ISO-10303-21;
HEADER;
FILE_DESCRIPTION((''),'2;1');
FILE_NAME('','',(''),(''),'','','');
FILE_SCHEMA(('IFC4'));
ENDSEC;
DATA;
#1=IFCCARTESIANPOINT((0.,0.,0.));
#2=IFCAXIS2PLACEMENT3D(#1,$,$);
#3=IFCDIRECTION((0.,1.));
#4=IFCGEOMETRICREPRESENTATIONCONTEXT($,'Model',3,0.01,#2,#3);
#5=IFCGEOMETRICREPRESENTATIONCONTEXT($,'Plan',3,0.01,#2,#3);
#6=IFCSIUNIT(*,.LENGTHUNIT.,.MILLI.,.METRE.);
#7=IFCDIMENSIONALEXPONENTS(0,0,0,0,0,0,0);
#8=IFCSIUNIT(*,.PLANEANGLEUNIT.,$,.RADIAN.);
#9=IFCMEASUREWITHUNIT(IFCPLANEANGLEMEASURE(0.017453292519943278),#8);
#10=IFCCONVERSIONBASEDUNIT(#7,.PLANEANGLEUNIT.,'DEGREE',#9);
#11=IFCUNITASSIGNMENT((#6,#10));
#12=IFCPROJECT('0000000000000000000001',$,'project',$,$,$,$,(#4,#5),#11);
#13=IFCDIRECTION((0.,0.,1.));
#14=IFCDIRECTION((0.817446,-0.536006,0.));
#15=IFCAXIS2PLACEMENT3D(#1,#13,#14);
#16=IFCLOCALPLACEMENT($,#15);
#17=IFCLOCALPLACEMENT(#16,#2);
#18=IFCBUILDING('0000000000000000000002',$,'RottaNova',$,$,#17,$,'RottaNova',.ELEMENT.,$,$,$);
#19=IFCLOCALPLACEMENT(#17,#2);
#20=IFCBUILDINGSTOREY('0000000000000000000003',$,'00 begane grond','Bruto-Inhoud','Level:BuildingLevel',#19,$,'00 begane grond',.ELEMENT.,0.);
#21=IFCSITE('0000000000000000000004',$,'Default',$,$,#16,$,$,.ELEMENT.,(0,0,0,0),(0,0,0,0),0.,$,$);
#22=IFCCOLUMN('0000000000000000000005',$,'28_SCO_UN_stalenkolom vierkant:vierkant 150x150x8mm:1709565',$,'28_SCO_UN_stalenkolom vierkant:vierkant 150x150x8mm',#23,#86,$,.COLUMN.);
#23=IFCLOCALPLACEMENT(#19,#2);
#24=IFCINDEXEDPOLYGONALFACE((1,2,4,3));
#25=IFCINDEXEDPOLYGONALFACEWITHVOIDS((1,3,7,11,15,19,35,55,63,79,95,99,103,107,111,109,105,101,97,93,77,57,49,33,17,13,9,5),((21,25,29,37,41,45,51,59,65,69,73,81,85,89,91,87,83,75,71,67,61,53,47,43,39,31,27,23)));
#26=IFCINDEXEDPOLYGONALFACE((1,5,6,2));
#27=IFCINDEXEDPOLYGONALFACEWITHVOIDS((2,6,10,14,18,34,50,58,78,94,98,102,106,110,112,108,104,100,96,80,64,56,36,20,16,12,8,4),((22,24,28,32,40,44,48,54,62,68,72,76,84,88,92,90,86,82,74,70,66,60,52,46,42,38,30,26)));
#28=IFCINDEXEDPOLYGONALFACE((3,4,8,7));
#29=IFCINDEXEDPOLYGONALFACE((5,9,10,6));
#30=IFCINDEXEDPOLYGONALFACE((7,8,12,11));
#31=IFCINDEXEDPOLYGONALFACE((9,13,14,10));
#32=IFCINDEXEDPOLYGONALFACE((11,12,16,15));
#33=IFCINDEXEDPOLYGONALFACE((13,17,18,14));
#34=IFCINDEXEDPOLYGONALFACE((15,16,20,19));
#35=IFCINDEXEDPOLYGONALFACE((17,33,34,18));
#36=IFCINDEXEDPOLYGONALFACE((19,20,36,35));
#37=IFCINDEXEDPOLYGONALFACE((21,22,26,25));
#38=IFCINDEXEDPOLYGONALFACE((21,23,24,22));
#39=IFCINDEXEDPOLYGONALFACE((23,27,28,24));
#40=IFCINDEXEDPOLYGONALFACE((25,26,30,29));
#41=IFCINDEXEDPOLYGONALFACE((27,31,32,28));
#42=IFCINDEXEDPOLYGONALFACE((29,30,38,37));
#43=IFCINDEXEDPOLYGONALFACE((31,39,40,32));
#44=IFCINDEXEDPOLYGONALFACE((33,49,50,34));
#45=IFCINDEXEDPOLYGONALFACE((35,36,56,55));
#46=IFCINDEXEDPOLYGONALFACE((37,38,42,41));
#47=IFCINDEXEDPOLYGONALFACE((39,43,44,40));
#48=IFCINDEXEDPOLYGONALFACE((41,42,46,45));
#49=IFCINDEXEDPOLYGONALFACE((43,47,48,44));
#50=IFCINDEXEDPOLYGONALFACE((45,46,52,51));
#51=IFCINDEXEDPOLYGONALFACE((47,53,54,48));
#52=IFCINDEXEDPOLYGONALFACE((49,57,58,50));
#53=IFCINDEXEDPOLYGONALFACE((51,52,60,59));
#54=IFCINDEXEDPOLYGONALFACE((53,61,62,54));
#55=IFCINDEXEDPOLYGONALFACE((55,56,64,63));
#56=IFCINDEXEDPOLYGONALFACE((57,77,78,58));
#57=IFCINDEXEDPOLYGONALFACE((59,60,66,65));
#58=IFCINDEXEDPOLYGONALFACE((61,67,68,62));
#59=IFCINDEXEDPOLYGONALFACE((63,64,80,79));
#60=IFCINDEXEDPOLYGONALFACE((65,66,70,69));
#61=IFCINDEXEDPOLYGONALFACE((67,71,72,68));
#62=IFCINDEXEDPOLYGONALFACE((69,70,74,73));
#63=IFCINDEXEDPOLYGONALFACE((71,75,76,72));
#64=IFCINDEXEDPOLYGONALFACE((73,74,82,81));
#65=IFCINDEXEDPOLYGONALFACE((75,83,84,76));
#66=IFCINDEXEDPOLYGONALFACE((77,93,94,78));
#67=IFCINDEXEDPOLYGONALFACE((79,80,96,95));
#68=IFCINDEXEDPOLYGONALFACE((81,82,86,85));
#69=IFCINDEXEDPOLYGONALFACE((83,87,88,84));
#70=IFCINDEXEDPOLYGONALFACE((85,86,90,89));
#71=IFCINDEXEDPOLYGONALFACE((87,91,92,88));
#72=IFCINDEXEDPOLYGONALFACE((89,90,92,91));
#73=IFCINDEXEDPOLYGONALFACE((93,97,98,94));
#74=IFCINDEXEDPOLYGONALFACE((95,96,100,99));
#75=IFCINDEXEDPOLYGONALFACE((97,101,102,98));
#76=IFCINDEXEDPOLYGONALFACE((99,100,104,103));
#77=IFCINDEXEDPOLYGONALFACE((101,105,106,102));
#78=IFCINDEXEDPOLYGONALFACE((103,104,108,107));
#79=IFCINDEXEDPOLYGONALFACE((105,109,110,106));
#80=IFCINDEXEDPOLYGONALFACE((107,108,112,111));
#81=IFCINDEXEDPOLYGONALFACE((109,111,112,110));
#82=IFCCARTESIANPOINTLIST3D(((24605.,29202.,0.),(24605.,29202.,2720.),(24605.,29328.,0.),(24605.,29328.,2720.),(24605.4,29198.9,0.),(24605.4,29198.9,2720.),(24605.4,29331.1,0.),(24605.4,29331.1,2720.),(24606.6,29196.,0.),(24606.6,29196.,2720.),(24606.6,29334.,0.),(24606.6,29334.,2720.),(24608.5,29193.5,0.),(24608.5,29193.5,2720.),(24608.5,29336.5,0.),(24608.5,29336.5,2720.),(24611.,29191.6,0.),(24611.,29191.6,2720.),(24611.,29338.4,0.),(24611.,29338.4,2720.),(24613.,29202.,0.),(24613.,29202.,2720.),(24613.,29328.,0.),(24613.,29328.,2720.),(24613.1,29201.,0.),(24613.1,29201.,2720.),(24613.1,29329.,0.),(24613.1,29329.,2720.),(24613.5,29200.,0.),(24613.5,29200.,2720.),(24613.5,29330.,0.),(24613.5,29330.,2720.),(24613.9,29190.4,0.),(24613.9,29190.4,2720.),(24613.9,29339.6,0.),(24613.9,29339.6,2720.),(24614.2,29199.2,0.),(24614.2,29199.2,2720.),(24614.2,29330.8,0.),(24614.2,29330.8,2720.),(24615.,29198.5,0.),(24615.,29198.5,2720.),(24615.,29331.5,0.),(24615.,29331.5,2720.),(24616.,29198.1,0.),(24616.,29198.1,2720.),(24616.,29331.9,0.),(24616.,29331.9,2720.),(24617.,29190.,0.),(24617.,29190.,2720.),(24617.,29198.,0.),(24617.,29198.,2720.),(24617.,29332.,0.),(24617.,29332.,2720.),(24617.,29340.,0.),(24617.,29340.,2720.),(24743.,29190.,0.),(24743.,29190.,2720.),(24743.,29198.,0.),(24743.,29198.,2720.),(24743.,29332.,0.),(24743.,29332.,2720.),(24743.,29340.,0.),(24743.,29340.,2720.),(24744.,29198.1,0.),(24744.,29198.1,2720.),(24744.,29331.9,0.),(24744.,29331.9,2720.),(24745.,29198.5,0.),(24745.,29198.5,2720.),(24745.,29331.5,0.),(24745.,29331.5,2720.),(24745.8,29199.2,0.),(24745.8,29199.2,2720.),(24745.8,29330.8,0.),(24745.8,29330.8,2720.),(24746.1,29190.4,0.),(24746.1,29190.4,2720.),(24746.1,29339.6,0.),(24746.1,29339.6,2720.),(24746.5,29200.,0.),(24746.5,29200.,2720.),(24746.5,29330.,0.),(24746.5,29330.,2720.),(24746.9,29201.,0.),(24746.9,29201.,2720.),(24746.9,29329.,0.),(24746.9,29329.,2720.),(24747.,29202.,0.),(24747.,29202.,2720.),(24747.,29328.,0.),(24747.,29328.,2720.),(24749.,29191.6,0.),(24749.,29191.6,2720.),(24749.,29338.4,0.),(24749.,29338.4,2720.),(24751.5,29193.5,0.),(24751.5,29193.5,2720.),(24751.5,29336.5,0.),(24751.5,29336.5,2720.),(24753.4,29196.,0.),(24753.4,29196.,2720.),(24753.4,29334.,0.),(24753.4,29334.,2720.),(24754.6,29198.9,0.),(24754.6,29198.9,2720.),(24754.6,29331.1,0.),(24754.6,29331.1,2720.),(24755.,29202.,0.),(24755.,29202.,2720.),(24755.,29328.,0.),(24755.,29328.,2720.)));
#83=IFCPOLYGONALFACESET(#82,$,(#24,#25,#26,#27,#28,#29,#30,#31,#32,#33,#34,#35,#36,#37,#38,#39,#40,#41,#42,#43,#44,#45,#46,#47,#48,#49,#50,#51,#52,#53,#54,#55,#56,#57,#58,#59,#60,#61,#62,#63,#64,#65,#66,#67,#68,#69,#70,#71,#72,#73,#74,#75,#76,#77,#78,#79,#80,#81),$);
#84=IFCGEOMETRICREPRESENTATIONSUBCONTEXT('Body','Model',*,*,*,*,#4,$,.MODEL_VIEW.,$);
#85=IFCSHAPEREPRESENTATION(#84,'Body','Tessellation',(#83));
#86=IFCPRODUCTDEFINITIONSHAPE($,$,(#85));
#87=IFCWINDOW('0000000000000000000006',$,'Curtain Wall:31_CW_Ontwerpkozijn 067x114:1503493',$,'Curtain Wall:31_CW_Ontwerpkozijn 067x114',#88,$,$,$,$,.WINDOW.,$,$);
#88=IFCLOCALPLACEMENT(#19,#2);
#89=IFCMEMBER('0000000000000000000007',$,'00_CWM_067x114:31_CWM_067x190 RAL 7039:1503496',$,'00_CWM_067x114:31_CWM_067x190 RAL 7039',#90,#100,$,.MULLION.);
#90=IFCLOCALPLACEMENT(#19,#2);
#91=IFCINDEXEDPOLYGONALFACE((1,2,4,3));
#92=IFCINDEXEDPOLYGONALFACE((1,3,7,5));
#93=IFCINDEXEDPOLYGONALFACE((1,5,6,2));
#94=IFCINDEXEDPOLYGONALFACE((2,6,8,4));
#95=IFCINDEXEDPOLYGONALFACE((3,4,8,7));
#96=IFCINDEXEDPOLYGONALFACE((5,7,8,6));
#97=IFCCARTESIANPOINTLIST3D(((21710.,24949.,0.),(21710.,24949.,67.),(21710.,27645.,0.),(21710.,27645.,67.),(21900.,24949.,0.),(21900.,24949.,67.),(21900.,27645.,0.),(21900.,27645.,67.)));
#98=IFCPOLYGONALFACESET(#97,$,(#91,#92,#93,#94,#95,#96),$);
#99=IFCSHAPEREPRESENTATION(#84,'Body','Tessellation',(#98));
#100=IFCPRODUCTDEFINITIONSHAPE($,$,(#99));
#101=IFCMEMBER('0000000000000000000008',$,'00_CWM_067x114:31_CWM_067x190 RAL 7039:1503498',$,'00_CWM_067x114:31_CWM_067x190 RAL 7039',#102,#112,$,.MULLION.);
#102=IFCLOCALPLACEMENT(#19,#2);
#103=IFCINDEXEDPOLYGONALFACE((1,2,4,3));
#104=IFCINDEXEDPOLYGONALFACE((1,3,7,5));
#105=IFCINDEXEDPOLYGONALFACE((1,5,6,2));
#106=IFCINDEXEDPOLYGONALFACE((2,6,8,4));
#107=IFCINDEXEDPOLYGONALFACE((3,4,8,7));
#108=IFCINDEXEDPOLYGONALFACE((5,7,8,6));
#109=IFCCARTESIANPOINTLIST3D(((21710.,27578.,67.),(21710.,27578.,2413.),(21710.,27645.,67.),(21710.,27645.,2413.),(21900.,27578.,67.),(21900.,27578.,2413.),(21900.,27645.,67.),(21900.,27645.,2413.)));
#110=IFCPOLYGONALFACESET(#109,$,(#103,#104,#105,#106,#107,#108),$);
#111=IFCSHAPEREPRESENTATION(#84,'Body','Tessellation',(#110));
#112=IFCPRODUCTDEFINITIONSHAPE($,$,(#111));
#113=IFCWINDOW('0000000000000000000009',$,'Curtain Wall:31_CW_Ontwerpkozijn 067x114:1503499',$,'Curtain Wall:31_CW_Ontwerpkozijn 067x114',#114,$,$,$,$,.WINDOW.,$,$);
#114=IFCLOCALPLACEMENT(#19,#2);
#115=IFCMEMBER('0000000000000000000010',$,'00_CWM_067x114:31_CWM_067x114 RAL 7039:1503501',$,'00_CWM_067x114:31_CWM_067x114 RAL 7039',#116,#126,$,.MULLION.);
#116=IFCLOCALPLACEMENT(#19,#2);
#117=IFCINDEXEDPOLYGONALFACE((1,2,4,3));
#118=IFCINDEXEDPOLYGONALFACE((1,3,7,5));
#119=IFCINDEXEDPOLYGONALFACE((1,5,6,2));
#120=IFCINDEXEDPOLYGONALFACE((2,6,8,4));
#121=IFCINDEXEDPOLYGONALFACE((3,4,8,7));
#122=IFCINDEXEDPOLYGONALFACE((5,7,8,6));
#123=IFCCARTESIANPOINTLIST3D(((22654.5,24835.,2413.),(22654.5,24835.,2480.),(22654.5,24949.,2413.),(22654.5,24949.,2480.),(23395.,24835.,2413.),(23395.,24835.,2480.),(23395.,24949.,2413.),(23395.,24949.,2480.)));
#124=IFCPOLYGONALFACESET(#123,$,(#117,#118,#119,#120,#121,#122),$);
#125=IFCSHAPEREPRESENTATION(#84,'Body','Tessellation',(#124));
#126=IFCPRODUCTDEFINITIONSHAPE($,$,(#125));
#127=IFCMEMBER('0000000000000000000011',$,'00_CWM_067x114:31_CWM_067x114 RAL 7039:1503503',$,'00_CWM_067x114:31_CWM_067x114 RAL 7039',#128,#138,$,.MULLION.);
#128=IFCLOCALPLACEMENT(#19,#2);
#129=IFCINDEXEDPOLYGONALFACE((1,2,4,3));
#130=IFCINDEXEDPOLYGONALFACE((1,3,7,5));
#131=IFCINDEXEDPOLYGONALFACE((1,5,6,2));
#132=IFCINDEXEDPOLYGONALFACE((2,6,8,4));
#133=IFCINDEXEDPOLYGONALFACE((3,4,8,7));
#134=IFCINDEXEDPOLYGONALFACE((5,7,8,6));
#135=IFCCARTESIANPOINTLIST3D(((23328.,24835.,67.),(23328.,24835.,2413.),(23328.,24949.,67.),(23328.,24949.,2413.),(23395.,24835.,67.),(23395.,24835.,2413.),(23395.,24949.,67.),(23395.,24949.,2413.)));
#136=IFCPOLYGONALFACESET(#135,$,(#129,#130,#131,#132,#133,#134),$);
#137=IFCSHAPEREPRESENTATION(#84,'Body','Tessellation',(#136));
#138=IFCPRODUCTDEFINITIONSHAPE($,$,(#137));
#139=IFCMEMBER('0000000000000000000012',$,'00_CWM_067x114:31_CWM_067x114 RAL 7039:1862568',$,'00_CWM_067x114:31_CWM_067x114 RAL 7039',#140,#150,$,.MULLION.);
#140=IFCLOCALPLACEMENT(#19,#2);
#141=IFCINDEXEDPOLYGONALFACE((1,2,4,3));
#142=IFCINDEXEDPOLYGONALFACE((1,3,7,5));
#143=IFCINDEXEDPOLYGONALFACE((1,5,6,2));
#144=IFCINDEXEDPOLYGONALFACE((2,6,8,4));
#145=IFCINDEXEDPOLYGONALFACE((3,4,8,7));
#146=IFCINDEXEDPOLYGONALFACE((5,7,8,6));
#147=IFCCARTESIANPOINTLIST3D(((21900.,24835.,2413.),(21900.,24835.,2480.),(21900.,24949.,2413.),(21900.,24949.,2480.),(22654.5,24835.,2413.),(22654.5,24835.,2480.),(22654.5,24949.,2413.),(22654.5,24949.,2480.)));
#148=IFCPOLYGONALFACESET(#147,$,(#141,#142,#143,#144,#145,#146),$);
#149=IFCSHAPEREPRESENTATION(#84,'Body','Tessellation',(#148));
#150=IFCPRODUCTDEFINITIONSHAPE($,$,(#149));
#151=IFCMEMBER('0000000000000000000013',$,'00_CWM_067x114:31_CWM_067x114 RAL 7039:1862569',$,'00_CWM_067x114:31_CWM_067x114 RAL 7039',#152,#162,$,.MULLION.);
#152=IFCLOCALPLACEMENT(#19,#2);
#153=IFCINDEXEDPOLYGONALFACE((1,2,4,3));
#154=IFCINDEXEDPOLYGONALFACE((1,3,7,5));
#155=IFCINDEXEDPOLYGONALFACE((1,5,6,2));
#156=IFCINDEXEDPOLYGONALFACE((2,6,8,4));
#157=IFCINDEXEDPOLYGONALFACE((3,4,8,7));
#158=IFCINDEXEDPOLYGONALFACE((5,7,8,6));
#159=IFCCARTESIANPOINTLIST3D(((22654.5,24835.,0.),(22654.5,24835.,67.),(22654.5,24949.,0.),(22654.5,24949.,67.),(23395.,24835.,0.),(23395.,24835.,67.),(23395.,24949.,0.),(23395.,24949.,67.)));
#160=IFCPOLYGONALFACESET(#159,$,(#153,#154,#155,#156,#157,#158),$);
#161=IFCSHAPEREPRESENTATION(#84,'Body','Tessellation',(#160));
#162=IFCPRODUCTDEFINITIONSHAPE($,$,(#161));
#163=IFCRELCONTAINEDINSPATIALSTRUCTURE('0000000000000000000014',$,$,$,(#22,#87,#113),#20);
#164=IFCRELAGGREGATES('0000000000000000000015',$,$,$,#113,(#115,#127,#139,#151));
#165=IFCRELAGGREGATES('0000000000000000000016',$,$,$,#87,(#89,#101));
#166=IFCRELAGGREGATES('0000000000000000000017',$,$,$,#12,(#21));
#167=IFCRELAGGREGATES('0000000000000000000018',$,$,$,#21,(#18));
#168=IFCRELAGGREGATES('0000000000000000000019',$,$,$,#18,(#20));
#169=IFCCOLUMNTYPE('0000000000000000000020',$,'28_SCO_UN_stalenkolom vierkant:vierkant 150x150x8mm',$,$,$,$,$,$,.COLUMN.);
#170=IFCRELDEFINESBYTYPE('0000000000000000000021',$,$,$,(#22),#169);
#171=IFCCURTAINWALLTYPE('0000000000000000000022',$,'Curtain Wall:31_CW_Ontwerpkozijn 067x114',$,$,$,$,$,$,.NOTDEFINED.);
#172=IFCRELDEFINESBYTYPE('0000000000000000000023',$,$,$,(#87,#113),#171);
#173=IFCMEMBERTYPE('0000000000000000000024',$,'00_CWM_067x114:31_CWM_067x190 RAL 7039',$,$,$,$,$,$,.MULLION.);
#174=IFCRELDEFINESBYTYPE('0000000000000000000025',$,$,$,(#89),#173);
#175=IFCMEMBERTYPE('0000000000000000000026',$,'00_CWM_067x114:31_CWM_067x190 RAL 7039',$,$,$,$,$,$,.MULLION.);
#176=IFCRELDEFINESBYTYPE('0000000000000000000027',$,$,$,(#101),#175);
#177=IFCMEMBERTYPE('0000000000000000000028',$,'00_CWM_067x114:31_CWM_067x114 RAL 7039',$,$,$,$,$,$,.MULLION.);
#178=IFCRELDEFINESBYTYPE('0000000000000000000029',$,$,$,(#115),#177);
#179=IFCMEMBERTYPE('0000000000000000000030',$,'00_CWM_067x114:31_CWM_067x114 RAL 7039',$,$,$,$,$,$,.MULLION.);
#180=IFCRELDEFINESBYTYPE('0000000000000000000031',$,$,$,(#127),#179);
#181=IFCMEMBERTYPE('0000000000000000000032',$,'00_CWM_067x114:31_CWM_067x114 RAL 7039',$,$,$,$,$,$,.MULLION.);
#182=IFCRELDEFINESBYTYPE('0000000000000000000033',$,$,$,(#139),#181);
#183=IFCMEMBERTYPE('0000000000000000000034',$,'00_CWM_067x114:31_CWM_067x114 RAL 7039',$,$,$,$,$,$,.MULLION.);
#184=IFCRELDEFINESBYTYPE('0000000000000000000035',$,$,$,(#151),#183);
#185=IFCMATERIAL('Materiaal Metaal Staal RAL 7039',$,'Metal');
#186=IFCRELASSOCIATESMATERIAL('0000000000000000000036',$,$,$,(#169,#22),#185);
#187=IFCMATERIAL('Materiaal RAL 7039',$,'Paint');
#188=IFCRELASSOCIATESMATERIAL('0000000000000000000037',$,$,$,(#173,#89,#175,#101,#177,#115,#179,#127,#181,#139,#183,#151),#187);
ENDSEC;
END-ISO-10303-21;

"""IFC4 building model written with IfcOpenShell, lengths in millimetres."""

from ifc_helpers import new_model, entity, si_unit, converted_unit, direction, frame, origin, place, context, subcontext, project, spatial, line, arc, indexed_curve, outline, extrude, source, transform, mapped, material, type_object, type_shapes, element, aggregate, save


model = new_model("IFC4")

# Units and contexts
model_context = context("Model", 3, precision=0.01, world=origin(), true_north=direction((0.0, 1.0)))
plan_context = context("Plan", 3, precision=0.01, world=origin(), true_north=direction((0.0, 1.0)))
body_context = subcontext(model_context, "Body", "Model", "MODEL_VIEW")
ifc_project = project(units=[si_unit("LENGTHUNIT", "METRE", prefix="MILLI"), converted_unit("PLANEANGLEUNIT", "DEGREE", entity("IfcPlaneAngleMeasure", 0.017453292519943278), si_unit("PLANEANGLEUNIT", "RADIAN"), dimensions=[0, 0, 0, 0, 0, 0, 0])], contexts=[model_context, plan_context])

# Site, building, storey
site_placement = place(None, frame((0.0, 0.0, 0.0), z_axis=(0.0, 0.0, 1.0), x_axis=(0.817446, -0.536006, 0.0)))
site = spatial("IfcSite", under=ifc_project, at=site_placement, Name="Default", CompositionType="ELEMENT", RefLatitude=(0, 0, 0, 0), RefLongitude=(0, 0, 0, 0), RefElevation=0.0)
building_placement = place(site_placement, origin())
building = spatial("IfcBuilding", under=site, at=building_placement, Name="RottaNova", LongName="RottaNova", CompositionType="ELEMENT")
storey_placement = place(building_placement, origin())
storey = spatial("IfcBuildingStorey", under=building, at=storey_placement, Name="00 begane grond", Description="Bruto-Inhoud", ObjectType="Level:BuildingLevel", LongName="00 begane grond", CompositionType="ELEMENT", Elevation=0.0)

# Column
ifc_material_1 = material(Name="Materiaal Metaal Staal RAL 7039", Category="Metal")
column_type = type_object("IfcColumnType", Name="28_SCO_UN_stalenkolom vierkant:vierkant 150x150x8mm", PredefinedType="COLUMN", material=ifc_material_1)
shared_shape_1 = source(origin(), body_context, "Body", "SweptSolid", [
    extrude(outline(indexed_curve([(-63.0, -75.0), (63.0, -75.0), (71.5, -71.5), (75.0, -63.0), (75.0, 63.0), (71.5, 71.5), (63.0, 75.0), (-63.0, 75.0), (-71.5, 71.5), (-75.0, 63.0), (-75.0, -63.0), (-71.5, -71.5)], segments=[line(1, 2), arc(2, 3, 4), line(4, 5), arc(5, 6, 7), line(7, 8), arc(8, 9, 10), line(10, 11), arc(11, 12, 1)], self_intersect=False), holes=[indexed_curve([(67.0, -63.0), (65.8, -65.8), (63.0, -67.0), (-63.0, -67.0), (-65.8, -65.8), (-67.0, -63.0), (-67.0, 63.0), (-65.8, 65.8), (-63.0, 67.0), (63.0, 67.0), (65.8, 65.8), (67.0, 63.0)], segments=[arc(1, 2, 3), line(3, 4), arc(4, 5, 6), line(6, 7), arc(7, 8, 9), line(9, 10), arc(10, 11, 12), line(12, 1)], self_intersect=False)]), frame((0.0, 0.0, 0.0), z_axis=(0.0, 0.0, 1.0), x_axis=(-1.0, 0.0, 0.0)), (0.0, 0.0, 1.0), 2720.0),
])
type_shapes(column_type, [shared_shape_1])
column_placement = place(storey_placement, frame((24680.0, 29265.0, 0.0)))
element("IfcColumn", 1, at=column_placement, inside=storey, type_object=column_type, material=ifc_material_1, Name="28_SCO_UN_stalenkolom vierkant:vierkant 150x150x8mm:1709565", ObjectType="28_SCO_UN_stalenkolom vierkant:vierkant 150x150x8mm", PredefinedType="COLUMN", context=body_context, shape_type="MappedRepresentation", body=[
    mapped(shared_shape_1, transform((0.0, 0.0, 0.0), scale=1.0)),
])

# Window, members
curtain_wall_type = type_object("IfcCurtainWallType", Name="Curtain Wall:31_CW_Ontwerpkozijn 067x114", PredefinedType="NOTDEFINED")
window_1_placement = place(storey_placement, origin())
window_1 = element("IfcWindow", 2, at=window_1_placement, inside=storey, type_object=curtain_wall_type, Name="Curtain Wall:31_CW_Ontwerpkozijn 067x114:1503493", ObjectType="Curtain Wall:31_CW_Ontwerpkozijn 067x114", PredefinedType="WINDOW")
ifc_material_2 = material(Name="Materiaal RAL 7039", Category="Paint")
member_type_1 = type_object("IfcMemberType", Name="00_CWM_067x114:31_CWM_067x190 RAL 7039", PredefinedType="MULLION", material=ifc_material_2)
shared_shape_2 = source(origin(), body_context, "Body", "SweptSolid", [
    extrude(outline(indexed_curve([(-33.5, -95.0), (33.5, -95.0), (33.5, 95.0), (-33.5, 95.0), (-33.5, -95.0)], self_intersect=False)), frame((-33.5, -95.0, -2696.0), z_axis=(0.0, 0.0, 1.0), x_axis=(-1.0, 0.0, 0.0)), (0.0, 0.0, 1.0), 2696.0),
])
type_shapes(member_type_1, [shared_shape_2])
member_1_placement = place(window_1_placement, frame((21710.0, 27645.0, 0.0), z_axis=(0.0, 1.0, 0.0), x_axis=(0.0, 0.0, -1.0)))
member_1 = element("IfcMember", 3, at=member_1_placement, type_object=member_type_1, material=ifc_material_2, Name="00_CWM_067x114:31_CWM_067x190 RAL 7039:1503496", ObjectType="00_CWM_067x114:31_CWM_067x190 RAL 7039", PredefinedType="MULLION", context=body_context, shape_type="MappedRepresentation", body=[
    mapped(shared_shape_2, transform((0.0, 0.0, 0.0), scale=1.0)),
])
member_type_2 = type_object("IfcMemberType", Name="00_CWM_067x114:31_CWM_067x190 RAL 7039", PredefinedType="MULLION", material=ifc_material_2)
shared_shape_3 = source(origin(), body_context, "Body", "SweptSolid", [
    extrude(outline(indexed_curve([(-33.5, -95.0), (33.5, -95.0), (33.5, 95.0), (-33.5, 95.0), (-33.5, -95.0)], self_intersect=False)), frame((-33.5, -95.0, -2346.0), z_axis=(0.0, 0.0, 1.0), x_axis=(-1.0, 0.0, 0.0)), (0.0, 0.0, 1.0), 2346.0),
])
type_shapes(member_type_2, [shared_shape_3])
member_2_placement = place(window_1_placement, frame((21710.0, 27645.0, 2413.0), z_axis=(0.0, 0.0, 1.0), x_axis=(0.0, 1.0, 0.0)))
member_2 = element("IfcMember", 4, at=member_2_placement, type_object=member_type_2, material=ifc_material_2, Name="00_CWM_067x114:31_CWM_067x190 RAL 7039:1503498", ObjectType="00_CWM_067x114:31_CWM_067x190 RAL 7039", PredefinedType="MULLION", context=body_context, shape_type="MappedRepresentation", body=[
    mapped(shared_shape_3, transform((0.0, 0.0, 0.0), scale=1.0)),
])

# Window, members
window_2_placement = place(storey_placement, origin())
window_2 = element("IfcWindow", 5, at=window_2_placement, inside=storey, type_object=curtain_wall_type, Name="Curtain Wall:31_CW_Ontwerpkozijn 067x114:1503499", ObjectType="Curtain Wall:31_CW_Ontwerpkozijn 067x114", PredefinedType="WINDOW")
member_type_3 = type_object("IfcMemberType", Name="00_CWM_067x114:31_CWM_067x114 RAL 7039", PredefinedType="MULLION", material=ifc_material_2)
shared_shape_4 = source(origin(), body_context, "Body", "SweptSolid", [
    extrude(outline(indexed_curve([(-33.5, -57.0), (33.5, -57.0), (33.5, 57.0), (-33.5, 57.0), (-33.5, -57.0)], self_intersect=False)), frame((-33.5, -57.0, -740.5), z_axis=(0.0, 0.0, 1.0), x_axis=(-1.0, 0.0, 0.0)), (0.0, 0.0, 1.0), 740.5),
])
type_shapes(member_type_3, [shared_shape_4])
member_3_placement = place(window_2_placement, frame((23395.0, 24835.0, 2480.0), z_axis=(1.0, 0.0, 0.0), x_axis=(0.0, 0.0, 1.0)))
member_3 = element("IfcMember", 6, at=member_3_placement, type_object=member_type_3, material=ifc_material_2, Name="00_CWM_067x114:31_CWM_067x114 RAL 7039:1503501", ObjectType="00_CWM_067x114:31_CWM_067x114 RAL 7039", PredefinedType="MULLION", context=body_context, shape_type="MappedRepresentation", body=[
    mapped(shared_shape_4, transform((0.0, 0.0, 0.0), scale=1.0)),
])
member_type_4 = type_object("IfcMemberType", Name="00_CWM_067x114:31_CWM_067x114 RAL 7039", PredefinedType="MULLION", material=ifc_material_2)
shared_shape_5 = source(origin(), body_context, "Body", "SweptSolid", [
    extrude(outline(indexed_curve([(-33.5, -57.0), (33.5, -57.0), (33.5, 57.0), (-33.5, 57.0), (-33.5, -57.0)], self_intersect=False)), frame((-33.5, -57.0, -2346.0), z_axis=(0.0, 0.0, 1.0), x_axis=(-1.0, 0.0, 0.0)), (0.0, 0.0, 1.0), 2346.0),
])
type_shapes(member_type_4, [shared_shape_5])
member_4_placement = place(window_2_placement, frame((23395.0, 24835.0, 67.0), z_axis=(0.0, 0.0, -1.0), x_axis=(1.0, 0.0, 0.0)))
member_4 = element("IfcMember", 7, at=member_4_placement, type_object=member_type_4, material=ifc_material_2, Name="00_CWM_067x114:31_CWM_067x114 RAL 7039:1503503", ObjectType="00_CWM_067x114:31_CWM_067x114 RAL 7039", PredefinedType="MULLION", context=body_context, shape_type="MappedRepresentation", body=[
    mapped(shared_shape_5, transform((0.0, 0.0, 0.0), scale=1.0)),
])
member_type_5 = type_object("IfcMemberType", Name="00_CWM_067x114:31_CWM_067x114 RAL 7039", PredefinedType="MULLION", material=ifc_material_2)
shared_shape_6 = source(origin(), body_context, "Body", "SweptSolid", [
    extrude(outline(indexed_curve([(-33.5, -57.0), (33.5, -57.0), (33.5, 57.0), (-33.5, 57.0), (-33.5, -57.0)], self_intersect=False)), frame((-33.5, -57.0, -754.5), z_axis=(0.0, 0.0, 1.0), x_axis=(-1.0, 0.0, 0.0)), (0.0, 0.0, 1.0), 754.5),
])
type_shapes(member_type_5, [shared_shape_6])
member_5_placement = place(window_2_placement, frame((22654.5, 24835.0, 2480.0), z_axis=(1.0, 0.0, 0.0), x_axis=(0.0, 0.0, 1.0)))
member_5 = element("IfcMember", 8, at=member_5_placement, type_object=member_type_5, material=ifc_material_2, Name="00_CWM_067x114:31_CWM_067x114 RAL 7039:1862568", ObjectType="00_CWM_067x114:31_CWM_067x114 RAL 7039", PredefinedType="MULLION", context=body_context, shape_type="MappedRepresentation", body=[
    mapped(shared_shape_6, transform((0.0, 0.0, 0.0), scale=1.0)),
])
member_type_6 = type_object("IfcMemberType", Name="00_CWM_067x114:31_CWM_067x114 RAL 7039", PredefinedType="MULLION", material=ifc_material_2)
shared_shape_7 = source(origin(), body_context, "Body", "SweptSolid", [
    extrude(outline(indexed_curve([(-33.5, -57.0), (33.5, -57.0), (33.5, 57.0), (-33.5, 57.0), (-33.5, -57.0)], self_intersect=False)), frame((-33.5, -57.0, -740.5), z_axis=(0.0, 0.0, 1.0), x_axis=(-1.0, 0.0, 0.0)), (0.0, 0.0, 1.0), 740.5),
])
type_shapes(member_type_6, [shared_shape_7])
member_6_placement = place(window_2_placement, frame((22654.5, 24835.0, 0.0), z_axis=(-1.0, 0.0, 0.0), x_axis=(0.0, 0.0, -1.0)))
member_6 = element("IfcMember", 9, at=member_6_placement, type_object=member_type_6, material=ifc_material_2, Name="00_CWM_067x114:31_CWM_067x114 RAL 7039:1862569", ObjectType="00_CWM_067x114:31_CWM_067x114 RAL 7039", PredefinedType="MULLION", context=body_context, shape_type="MappedRepresentation", body=[
    mapped(shared_shape_7, transform((0.0, 0.0, 0.0), scale=1.0)),
])
aggregate(window_2, [member_3, member_4, member_5, member_6])

aggregate(window_1, [member_1, member_2])

save(model, "model.ifc")
